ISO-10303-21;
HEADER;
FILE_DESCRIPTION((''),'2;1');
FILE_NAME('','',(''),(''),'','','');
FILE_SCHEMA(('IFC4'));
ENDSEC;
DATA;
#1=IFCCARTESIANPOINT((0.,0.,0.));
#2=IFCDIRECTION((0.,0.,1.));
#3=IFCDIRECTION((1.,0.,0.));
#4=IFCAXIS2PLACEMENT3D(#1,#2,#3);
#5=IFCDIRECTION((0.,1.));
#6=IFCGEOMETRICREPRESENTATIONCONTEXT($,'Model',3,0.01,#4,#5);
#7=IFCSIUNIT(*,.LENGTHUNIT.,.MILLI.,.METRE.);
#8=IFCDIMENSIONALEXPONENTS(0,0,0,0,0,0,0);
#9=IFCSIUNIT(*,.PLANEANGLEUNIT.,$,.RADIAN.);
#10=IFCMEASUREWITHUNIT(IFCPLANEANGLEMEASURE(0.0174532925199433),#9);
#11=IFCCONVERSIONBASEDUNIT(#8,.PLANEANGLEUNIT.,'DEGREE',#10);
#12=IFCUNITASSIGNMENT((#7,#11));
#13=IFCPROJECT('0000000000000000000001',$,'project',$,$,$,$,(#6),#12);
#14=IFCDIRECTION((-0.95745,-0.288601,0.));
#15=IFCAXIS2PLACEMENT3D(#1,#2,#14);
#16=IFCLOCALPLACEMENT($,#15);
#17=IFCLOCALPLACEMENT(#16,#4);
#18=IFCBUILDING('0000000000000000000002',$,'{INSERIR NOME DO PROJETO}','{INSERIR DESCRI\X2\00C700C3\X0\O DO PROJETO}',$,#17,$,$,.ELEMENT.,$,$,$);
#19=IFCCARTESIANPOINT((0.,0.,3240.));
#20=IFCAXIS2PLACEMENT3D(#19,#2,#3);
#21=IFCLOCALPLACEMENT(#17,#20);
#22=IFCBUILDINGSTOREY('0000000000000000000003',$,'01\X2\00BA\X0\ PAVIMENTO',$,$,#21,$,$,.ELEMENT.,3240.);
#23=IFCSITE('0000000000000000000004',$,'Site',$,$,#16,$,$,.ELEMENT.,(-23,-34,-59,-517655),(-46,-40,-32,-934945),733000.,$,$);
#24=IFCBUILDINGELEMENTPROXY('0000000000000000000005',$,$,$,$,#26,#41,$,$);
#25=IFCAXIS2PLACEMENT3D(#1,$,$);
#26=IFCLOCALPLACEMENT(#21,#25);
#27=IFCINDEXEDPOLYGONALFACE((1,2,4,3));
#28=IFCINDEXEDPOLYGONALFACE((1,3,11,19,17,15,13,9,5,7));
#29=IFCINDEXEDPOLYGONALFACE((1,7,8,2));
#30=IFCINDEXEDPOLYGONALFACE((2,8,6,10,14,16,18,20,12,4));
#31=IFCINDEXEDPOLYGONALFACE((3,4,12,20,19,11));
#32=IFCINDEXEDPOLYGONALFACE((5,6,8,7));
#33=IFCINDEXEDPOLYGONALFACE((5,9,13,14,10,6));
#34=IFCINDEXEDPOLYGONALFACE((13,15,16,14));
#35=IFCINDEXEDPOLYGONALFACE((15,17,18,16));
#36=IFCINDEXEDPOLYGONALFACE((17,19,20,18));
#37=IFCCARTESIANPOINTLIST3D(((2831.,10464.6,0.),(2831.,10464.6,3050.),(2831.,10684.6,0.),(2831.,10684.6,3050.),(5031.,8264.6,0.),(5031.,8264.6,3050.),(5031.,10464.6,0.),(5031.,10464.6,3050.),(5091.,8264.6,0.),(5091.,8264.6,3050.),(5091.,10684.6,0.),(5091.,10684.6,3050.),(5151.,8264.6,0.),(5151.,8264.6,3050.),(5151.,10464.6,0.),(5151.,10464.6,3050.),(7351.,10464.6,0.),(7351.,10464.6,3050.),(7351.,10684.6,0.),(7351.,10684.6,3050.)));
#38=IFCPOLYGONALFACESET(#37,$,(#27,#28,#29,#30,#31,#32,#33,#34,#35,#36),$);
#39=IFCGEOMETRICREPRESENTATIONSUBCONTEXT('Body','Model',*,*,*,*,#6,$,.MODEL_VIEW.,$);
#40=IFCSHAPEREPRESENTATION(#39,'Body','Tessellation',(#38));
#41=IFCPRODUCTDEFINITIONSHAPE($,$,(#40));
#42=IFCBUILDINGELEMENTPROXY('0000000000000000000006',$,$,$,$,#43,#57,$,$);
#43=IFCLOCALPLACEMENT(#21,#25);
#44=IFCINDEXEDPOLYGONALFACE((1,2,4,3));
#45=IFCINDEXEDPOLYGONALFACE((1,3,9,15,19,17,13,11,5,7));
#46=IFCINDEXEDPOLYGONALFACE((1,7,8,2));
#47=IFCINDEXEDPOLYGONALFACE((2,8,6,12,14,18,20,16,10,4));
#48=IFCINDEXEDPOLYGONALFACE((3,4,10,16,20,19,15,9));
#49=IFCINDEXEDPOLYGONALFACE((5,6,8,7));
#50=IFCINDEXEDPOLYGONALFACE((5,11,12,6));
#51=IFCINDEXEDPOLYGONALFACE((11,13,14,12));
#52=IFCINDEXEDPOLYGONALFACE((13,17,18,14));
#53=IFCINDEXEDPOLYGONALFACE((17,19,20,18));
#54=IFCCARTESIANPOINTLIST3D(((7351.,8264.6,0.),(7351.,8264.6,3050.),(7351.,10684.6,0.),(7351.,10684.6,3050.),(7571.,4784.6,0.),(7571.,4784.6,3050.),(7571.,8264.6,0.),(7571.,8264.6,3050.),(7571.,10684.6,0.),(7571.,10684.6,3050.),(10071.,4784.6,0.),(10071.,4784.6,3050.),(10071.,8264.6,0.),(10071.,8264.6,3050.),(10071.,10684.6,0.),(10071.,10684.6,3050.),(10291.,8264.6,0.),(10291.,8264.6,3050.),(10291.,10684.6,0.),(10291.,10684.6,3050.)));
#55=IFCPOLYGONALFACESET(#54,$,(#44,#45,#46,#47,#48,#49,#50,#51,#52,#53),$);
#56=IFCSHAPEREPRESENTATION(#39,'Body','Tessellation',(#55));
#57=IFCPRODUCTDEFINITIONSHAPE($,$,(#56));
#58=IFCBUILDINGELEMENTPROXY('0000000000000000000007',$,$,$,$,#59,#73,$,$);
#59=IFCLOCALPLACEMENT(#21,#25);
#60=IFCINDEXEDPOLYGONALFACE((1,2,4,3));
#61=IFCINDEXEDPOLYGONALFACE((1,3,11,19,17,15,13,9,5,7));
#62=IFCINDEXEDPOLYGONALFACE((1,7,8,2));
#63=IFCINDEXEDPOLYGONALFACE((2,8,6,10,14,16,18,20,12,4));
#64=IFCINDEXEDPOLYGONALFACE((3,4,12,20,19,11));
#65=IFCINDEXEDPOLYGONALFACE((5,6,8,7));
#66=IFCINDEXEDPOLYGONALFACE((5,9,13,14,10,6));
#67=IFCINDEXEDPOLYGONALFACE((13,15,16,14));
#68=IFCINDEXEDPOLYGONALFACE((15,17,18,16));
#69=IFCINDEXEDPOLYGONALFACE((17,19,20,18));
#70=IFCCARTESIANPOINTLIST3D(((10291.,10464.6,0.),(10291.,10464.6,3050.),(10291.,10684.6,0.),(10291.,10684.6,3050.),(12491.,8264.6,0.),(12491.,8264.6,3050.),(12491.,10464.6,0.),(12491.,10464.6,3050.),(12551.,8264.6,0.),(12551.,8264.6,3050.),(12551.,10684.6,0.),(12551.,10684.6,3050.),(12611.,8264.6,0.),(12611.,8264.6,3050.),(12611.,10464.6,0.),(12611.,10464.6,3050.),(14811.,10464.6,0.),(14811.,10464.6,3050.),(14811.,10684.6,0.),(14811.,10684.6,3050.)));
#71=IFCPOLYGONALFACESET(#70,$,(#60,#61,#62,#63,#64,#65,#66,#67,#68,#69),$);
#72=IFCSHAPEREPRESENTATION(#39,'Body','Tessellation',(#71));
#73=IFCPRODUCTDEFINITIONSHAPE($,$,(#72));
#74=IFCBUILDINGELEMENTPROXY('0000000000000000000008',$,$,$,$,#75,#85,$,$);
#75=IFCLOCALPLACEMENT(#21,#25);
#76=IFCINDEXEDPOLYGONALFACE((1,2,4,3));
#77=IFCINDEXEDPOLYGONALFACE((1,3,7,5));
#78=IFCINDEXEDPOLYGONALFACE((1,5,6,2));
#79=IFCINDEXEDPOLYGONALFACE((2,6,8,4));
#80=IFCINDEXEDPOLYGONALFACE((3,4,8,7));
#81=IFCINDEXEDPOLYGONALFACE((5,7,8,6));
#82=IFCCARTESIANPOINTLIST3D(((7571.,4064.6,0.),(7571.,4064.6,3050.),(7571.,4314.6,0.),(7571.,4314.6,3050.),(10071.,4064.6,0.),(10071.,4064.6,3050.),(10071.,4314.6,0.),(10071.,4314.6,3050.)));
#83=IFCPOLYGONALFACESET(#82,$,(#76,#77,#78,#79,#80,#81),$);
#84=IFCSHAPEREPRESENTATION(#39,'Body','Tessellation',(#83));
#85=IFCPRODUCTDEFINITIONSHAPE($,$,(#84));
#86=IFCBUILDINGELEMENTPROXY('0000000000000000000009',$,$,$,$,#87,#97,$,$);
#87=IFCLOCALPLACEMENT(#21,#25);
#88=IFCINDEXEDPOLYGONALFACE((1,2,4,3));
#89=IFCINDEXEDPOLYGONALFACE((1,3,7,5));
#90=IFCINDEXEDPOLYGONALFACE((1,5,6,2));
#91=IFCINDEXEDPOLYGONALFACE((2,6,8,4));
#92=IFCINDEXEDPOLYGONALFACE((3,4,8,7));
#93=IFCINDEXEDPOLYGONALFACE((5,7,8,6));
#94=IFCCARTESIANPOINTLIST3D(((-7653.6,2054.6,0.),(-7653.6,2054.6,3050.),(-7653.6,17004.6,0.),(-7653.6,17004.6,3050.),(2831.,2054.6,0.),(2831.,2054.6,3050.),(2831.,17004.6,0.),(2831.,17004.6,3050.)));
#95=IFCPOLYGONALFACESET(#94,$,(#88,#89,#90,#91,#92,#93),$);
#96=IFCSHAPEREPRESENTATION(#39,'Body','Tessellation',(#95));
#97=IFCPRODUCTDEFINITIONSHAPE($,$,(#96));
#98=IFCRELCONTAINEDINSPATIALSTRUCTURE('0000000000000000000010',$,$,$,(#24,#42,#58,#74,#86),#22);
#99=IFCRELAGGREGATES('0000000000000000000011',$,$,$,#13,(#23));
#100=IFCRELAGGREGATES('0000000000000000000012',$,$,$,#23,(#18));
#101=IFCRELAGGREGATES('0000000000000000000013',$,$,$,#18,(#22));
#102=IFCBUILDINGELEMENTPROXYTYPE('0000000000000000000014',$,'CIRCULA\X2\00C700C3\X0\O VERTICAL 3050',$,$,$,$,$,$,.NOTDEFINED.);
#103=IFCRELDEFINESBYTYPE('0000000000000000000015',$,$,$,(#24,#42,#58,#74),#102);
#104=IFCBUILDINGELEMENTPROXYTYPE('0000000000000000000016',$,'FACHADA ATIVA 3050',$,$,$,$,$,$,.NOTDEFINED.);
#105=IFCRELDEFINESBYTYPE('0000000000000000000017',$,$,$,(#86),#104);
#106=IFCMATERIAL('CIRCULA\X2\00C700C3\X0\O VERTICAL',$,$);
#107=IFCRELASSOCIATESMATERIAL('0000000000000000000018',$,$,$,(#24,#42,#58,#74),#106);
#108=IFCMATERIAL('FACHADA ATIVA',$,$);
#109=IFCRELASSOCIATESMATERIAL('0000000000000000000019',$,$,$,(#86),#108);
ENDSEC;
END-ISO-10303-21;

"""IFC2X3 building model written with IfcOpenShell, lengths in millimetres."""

from ifc_helpers import new_model, entity, si_unit, converted_unit, direction, frame, origin_with_axes, place, context, subcontext, project, spatial, polyline, outline, extrude, material, type_object, element, save


model = new_model("IFC2X3")

# Units and contexts
model_context = context("Model", 3, precision=0.01, world=origin_with_axes(), true_north=direction((0.0, 1.0)))
body_context = subcontext(model_context, "Body", "Model", "MODEL_VIEW")
ifc_project = project(units=[si_unit("LENGTHUNIT", "METRE", prefix="MILLI"), converted_unit("PLANEANGLEUNIT", "DEGREE", entity("IfcPlaneAngleMeasure", 0.0174532925199433), si_unit("PLANEANGLEUNIT", "RADIAN"), dimensions=[0, 0, 0, 0, 0, 0, 0])], contexts=[model_context])

# Site, building, storey
site_placement = place(None, frame((0.0, 0.0, 0.0), z_axis=(0.0, 0.0, 1.0), x_axis=(-0.95745, -0.288601, 0.0)))
site = spatial("IfcSite", under=ifc_project, at=site_placement, Name="Site", CompositionType="ELEMENT", RefLatitude=(-23, -34, -59, -517655), RefLongitude=(-46, -40, -32, -934945), RefElevation=733000.0)
building_placement = place(site_placement, origin_with_axes())
building = spatial("IfcBuilding", under=site, at=building_placement, Name="{INSERIR NOME DO PROJETO}", Description="{INSERIR DESCRIÇÃO DO PROJETO}", CompositionType="ELEMENT")
storey_placement = place(building_placement, frame((0.0, 0.0, 3240.0), z_axis=(0.0, 0.0, 1.0), x_axis=(1.0, 0.0, 0.0)))
storey = spatial("IfcBuildingStorey", under=building, at=storey_placement, Name="01º PAVIMENTO", CompositionType="ELEMENT", Elevation=3240.0)

# Building element proxies
ifc_material_1 = material(Name="CIRCULAÇÃO VERTICAL")
building_element_proxy_type_1 = type_object("IfcBuildingElementProxyType", Name="CIRCULAÇÃO VERTICAL 3050", PredefinedType="NOTDEFINED")
proxy_1_placement = place(storey_placement, frame((5091.0, 10684.6, 0.0), z_axis=(0.0, 0.0, 1.0), x_axis=(1.0, 0.0, 0.0)))
element("IfcBuildingElementProxy", 1, at=proxy_1_placement, inside=storey, type_object=building_element_proxy_type_1, material=ifc_material_1, context=body_context, shape_type="SweptSolid", body=[
    extrude(outline(polyline([(0.0, 0.0), (-2260.0, 0.0), (-2260.0, -220.0), (-60.0, -220.0), (-60.0, -2420.0), (0.0, -2420.0), (60.0, -2420.0), (60.0, -220.0), (2260.0, -220.0), (2260.0, 0.0), (0.0, 0.0)])), origin_with_axes(), (0.0, 0.0, 1.0), 3050.0),
])
proxy_2_placement = place(storey_placement, frame((7351.0, 10684.6, 0.0), z_axis=(0.0, 0.0, 1.0), x_axis=(1.0, 0.0, 0.0)))
element("IfcBuildingElementProxy", 2, at=proxy_2_placement, inside=storey, type_object=building_element_proxy_type_1, material=ifc_material_1, context=body_context, shape_type="SweptSolid", body=[
    extrude(outline(polyline([(0.0, 0.0), (0.0, -2420.0), (220.0, -2420.0), (220.0, -5900.0), (2720.0, -5900.0), (2720.0, -2420.0), (2940.0, -2420.0), (2940.0, 0.0), (2720.0, 0.0), (220.0, 0.0), (0.0, 0.0)])), origin_with_axes(), (0.0, 0.0, 1.0), 3050.0),
])
proxy_3_placement = place(storey_placement, frame((10291.0, 10684.6, 0.0), z_axis=(0.0, 0.0, 1.0), x_axis=(1.0, 0.0, 0.0)))
element("IfcBuildingElementProxy", 3, at=proxy_3_placement, inside=storey, type_object=building_element_proxy_type_1, material=ifc_material_1, context=body_context, shape_type="SweptSolid", body=[
    extrude(outline(polyline([(0.0, 0.0), (0.0, -220.0), (2200.0, -220.0), (2200.0, -2420.0), (2260.0, -2420.0), (2320.0, -2420.0), (2320.0, -220.0), (4520.0, -220.0), (4520.0, 0.0), (2260.0, 0.0), (0.0, 0.0)])), origin_with_axes(), (0.0, 0.0, 1.0), 3050.0),
])
proxy_4_placement = place(storey_placement, frame((7571.0, 4064.6, 0.0), z_axis=(0.0, 0.0, 1.0), x_axis=(1.0, 0.0, 0.0)))
element("IfcBuildingElementProxy", 4, at=proxy_4_placement, inside=storey, type_object=building_element_proxy_type_1, material=ifc_material_1, context=body_context, shape_type="SweptSolid", body=[
    extrude(outline(polyline([(0.0, 0.0), (2500.0, 0.0), (2500.0, 250.0), (0.0, 250.0), (0.0, 0.0)])), origin_with_axes(), (0.0, 0.0, 1.0), 3050.0),
])
ifc_material_2 = material(Name="FACHADA ATIVA")
building_element_proxy_type_2 = type_object("IfcBuildingElementProxyType", Name="FACHADA ATIVA 3050", PredefinedType="NOTDEFINED")
proxy_5_placement = place(storey_placement, frame((-7653.6, 17004.6, 0.0), z_axis=(0.0, 0.0, 1.0), x_axis=(1.0, 0.0, 0.0)))
element("IfcBuildingElementProxy", 5, at=proxy_5_placement, inside=storey, type_object=building_element_proxy_type_2, material=ifc_material_2, context=body_context, shape_type="SweptSolid", body=[
    extrude(outline(polyline([(0.0, 0.0), (0.0, -14950.0), (10484.6, -14950.0), (10484.6, 0.0), (0.0, 0.0)])), origin_with_axes(), (0.0, 0.0, 1.0), 3050.0),
])

save(model, "model.ifc")
